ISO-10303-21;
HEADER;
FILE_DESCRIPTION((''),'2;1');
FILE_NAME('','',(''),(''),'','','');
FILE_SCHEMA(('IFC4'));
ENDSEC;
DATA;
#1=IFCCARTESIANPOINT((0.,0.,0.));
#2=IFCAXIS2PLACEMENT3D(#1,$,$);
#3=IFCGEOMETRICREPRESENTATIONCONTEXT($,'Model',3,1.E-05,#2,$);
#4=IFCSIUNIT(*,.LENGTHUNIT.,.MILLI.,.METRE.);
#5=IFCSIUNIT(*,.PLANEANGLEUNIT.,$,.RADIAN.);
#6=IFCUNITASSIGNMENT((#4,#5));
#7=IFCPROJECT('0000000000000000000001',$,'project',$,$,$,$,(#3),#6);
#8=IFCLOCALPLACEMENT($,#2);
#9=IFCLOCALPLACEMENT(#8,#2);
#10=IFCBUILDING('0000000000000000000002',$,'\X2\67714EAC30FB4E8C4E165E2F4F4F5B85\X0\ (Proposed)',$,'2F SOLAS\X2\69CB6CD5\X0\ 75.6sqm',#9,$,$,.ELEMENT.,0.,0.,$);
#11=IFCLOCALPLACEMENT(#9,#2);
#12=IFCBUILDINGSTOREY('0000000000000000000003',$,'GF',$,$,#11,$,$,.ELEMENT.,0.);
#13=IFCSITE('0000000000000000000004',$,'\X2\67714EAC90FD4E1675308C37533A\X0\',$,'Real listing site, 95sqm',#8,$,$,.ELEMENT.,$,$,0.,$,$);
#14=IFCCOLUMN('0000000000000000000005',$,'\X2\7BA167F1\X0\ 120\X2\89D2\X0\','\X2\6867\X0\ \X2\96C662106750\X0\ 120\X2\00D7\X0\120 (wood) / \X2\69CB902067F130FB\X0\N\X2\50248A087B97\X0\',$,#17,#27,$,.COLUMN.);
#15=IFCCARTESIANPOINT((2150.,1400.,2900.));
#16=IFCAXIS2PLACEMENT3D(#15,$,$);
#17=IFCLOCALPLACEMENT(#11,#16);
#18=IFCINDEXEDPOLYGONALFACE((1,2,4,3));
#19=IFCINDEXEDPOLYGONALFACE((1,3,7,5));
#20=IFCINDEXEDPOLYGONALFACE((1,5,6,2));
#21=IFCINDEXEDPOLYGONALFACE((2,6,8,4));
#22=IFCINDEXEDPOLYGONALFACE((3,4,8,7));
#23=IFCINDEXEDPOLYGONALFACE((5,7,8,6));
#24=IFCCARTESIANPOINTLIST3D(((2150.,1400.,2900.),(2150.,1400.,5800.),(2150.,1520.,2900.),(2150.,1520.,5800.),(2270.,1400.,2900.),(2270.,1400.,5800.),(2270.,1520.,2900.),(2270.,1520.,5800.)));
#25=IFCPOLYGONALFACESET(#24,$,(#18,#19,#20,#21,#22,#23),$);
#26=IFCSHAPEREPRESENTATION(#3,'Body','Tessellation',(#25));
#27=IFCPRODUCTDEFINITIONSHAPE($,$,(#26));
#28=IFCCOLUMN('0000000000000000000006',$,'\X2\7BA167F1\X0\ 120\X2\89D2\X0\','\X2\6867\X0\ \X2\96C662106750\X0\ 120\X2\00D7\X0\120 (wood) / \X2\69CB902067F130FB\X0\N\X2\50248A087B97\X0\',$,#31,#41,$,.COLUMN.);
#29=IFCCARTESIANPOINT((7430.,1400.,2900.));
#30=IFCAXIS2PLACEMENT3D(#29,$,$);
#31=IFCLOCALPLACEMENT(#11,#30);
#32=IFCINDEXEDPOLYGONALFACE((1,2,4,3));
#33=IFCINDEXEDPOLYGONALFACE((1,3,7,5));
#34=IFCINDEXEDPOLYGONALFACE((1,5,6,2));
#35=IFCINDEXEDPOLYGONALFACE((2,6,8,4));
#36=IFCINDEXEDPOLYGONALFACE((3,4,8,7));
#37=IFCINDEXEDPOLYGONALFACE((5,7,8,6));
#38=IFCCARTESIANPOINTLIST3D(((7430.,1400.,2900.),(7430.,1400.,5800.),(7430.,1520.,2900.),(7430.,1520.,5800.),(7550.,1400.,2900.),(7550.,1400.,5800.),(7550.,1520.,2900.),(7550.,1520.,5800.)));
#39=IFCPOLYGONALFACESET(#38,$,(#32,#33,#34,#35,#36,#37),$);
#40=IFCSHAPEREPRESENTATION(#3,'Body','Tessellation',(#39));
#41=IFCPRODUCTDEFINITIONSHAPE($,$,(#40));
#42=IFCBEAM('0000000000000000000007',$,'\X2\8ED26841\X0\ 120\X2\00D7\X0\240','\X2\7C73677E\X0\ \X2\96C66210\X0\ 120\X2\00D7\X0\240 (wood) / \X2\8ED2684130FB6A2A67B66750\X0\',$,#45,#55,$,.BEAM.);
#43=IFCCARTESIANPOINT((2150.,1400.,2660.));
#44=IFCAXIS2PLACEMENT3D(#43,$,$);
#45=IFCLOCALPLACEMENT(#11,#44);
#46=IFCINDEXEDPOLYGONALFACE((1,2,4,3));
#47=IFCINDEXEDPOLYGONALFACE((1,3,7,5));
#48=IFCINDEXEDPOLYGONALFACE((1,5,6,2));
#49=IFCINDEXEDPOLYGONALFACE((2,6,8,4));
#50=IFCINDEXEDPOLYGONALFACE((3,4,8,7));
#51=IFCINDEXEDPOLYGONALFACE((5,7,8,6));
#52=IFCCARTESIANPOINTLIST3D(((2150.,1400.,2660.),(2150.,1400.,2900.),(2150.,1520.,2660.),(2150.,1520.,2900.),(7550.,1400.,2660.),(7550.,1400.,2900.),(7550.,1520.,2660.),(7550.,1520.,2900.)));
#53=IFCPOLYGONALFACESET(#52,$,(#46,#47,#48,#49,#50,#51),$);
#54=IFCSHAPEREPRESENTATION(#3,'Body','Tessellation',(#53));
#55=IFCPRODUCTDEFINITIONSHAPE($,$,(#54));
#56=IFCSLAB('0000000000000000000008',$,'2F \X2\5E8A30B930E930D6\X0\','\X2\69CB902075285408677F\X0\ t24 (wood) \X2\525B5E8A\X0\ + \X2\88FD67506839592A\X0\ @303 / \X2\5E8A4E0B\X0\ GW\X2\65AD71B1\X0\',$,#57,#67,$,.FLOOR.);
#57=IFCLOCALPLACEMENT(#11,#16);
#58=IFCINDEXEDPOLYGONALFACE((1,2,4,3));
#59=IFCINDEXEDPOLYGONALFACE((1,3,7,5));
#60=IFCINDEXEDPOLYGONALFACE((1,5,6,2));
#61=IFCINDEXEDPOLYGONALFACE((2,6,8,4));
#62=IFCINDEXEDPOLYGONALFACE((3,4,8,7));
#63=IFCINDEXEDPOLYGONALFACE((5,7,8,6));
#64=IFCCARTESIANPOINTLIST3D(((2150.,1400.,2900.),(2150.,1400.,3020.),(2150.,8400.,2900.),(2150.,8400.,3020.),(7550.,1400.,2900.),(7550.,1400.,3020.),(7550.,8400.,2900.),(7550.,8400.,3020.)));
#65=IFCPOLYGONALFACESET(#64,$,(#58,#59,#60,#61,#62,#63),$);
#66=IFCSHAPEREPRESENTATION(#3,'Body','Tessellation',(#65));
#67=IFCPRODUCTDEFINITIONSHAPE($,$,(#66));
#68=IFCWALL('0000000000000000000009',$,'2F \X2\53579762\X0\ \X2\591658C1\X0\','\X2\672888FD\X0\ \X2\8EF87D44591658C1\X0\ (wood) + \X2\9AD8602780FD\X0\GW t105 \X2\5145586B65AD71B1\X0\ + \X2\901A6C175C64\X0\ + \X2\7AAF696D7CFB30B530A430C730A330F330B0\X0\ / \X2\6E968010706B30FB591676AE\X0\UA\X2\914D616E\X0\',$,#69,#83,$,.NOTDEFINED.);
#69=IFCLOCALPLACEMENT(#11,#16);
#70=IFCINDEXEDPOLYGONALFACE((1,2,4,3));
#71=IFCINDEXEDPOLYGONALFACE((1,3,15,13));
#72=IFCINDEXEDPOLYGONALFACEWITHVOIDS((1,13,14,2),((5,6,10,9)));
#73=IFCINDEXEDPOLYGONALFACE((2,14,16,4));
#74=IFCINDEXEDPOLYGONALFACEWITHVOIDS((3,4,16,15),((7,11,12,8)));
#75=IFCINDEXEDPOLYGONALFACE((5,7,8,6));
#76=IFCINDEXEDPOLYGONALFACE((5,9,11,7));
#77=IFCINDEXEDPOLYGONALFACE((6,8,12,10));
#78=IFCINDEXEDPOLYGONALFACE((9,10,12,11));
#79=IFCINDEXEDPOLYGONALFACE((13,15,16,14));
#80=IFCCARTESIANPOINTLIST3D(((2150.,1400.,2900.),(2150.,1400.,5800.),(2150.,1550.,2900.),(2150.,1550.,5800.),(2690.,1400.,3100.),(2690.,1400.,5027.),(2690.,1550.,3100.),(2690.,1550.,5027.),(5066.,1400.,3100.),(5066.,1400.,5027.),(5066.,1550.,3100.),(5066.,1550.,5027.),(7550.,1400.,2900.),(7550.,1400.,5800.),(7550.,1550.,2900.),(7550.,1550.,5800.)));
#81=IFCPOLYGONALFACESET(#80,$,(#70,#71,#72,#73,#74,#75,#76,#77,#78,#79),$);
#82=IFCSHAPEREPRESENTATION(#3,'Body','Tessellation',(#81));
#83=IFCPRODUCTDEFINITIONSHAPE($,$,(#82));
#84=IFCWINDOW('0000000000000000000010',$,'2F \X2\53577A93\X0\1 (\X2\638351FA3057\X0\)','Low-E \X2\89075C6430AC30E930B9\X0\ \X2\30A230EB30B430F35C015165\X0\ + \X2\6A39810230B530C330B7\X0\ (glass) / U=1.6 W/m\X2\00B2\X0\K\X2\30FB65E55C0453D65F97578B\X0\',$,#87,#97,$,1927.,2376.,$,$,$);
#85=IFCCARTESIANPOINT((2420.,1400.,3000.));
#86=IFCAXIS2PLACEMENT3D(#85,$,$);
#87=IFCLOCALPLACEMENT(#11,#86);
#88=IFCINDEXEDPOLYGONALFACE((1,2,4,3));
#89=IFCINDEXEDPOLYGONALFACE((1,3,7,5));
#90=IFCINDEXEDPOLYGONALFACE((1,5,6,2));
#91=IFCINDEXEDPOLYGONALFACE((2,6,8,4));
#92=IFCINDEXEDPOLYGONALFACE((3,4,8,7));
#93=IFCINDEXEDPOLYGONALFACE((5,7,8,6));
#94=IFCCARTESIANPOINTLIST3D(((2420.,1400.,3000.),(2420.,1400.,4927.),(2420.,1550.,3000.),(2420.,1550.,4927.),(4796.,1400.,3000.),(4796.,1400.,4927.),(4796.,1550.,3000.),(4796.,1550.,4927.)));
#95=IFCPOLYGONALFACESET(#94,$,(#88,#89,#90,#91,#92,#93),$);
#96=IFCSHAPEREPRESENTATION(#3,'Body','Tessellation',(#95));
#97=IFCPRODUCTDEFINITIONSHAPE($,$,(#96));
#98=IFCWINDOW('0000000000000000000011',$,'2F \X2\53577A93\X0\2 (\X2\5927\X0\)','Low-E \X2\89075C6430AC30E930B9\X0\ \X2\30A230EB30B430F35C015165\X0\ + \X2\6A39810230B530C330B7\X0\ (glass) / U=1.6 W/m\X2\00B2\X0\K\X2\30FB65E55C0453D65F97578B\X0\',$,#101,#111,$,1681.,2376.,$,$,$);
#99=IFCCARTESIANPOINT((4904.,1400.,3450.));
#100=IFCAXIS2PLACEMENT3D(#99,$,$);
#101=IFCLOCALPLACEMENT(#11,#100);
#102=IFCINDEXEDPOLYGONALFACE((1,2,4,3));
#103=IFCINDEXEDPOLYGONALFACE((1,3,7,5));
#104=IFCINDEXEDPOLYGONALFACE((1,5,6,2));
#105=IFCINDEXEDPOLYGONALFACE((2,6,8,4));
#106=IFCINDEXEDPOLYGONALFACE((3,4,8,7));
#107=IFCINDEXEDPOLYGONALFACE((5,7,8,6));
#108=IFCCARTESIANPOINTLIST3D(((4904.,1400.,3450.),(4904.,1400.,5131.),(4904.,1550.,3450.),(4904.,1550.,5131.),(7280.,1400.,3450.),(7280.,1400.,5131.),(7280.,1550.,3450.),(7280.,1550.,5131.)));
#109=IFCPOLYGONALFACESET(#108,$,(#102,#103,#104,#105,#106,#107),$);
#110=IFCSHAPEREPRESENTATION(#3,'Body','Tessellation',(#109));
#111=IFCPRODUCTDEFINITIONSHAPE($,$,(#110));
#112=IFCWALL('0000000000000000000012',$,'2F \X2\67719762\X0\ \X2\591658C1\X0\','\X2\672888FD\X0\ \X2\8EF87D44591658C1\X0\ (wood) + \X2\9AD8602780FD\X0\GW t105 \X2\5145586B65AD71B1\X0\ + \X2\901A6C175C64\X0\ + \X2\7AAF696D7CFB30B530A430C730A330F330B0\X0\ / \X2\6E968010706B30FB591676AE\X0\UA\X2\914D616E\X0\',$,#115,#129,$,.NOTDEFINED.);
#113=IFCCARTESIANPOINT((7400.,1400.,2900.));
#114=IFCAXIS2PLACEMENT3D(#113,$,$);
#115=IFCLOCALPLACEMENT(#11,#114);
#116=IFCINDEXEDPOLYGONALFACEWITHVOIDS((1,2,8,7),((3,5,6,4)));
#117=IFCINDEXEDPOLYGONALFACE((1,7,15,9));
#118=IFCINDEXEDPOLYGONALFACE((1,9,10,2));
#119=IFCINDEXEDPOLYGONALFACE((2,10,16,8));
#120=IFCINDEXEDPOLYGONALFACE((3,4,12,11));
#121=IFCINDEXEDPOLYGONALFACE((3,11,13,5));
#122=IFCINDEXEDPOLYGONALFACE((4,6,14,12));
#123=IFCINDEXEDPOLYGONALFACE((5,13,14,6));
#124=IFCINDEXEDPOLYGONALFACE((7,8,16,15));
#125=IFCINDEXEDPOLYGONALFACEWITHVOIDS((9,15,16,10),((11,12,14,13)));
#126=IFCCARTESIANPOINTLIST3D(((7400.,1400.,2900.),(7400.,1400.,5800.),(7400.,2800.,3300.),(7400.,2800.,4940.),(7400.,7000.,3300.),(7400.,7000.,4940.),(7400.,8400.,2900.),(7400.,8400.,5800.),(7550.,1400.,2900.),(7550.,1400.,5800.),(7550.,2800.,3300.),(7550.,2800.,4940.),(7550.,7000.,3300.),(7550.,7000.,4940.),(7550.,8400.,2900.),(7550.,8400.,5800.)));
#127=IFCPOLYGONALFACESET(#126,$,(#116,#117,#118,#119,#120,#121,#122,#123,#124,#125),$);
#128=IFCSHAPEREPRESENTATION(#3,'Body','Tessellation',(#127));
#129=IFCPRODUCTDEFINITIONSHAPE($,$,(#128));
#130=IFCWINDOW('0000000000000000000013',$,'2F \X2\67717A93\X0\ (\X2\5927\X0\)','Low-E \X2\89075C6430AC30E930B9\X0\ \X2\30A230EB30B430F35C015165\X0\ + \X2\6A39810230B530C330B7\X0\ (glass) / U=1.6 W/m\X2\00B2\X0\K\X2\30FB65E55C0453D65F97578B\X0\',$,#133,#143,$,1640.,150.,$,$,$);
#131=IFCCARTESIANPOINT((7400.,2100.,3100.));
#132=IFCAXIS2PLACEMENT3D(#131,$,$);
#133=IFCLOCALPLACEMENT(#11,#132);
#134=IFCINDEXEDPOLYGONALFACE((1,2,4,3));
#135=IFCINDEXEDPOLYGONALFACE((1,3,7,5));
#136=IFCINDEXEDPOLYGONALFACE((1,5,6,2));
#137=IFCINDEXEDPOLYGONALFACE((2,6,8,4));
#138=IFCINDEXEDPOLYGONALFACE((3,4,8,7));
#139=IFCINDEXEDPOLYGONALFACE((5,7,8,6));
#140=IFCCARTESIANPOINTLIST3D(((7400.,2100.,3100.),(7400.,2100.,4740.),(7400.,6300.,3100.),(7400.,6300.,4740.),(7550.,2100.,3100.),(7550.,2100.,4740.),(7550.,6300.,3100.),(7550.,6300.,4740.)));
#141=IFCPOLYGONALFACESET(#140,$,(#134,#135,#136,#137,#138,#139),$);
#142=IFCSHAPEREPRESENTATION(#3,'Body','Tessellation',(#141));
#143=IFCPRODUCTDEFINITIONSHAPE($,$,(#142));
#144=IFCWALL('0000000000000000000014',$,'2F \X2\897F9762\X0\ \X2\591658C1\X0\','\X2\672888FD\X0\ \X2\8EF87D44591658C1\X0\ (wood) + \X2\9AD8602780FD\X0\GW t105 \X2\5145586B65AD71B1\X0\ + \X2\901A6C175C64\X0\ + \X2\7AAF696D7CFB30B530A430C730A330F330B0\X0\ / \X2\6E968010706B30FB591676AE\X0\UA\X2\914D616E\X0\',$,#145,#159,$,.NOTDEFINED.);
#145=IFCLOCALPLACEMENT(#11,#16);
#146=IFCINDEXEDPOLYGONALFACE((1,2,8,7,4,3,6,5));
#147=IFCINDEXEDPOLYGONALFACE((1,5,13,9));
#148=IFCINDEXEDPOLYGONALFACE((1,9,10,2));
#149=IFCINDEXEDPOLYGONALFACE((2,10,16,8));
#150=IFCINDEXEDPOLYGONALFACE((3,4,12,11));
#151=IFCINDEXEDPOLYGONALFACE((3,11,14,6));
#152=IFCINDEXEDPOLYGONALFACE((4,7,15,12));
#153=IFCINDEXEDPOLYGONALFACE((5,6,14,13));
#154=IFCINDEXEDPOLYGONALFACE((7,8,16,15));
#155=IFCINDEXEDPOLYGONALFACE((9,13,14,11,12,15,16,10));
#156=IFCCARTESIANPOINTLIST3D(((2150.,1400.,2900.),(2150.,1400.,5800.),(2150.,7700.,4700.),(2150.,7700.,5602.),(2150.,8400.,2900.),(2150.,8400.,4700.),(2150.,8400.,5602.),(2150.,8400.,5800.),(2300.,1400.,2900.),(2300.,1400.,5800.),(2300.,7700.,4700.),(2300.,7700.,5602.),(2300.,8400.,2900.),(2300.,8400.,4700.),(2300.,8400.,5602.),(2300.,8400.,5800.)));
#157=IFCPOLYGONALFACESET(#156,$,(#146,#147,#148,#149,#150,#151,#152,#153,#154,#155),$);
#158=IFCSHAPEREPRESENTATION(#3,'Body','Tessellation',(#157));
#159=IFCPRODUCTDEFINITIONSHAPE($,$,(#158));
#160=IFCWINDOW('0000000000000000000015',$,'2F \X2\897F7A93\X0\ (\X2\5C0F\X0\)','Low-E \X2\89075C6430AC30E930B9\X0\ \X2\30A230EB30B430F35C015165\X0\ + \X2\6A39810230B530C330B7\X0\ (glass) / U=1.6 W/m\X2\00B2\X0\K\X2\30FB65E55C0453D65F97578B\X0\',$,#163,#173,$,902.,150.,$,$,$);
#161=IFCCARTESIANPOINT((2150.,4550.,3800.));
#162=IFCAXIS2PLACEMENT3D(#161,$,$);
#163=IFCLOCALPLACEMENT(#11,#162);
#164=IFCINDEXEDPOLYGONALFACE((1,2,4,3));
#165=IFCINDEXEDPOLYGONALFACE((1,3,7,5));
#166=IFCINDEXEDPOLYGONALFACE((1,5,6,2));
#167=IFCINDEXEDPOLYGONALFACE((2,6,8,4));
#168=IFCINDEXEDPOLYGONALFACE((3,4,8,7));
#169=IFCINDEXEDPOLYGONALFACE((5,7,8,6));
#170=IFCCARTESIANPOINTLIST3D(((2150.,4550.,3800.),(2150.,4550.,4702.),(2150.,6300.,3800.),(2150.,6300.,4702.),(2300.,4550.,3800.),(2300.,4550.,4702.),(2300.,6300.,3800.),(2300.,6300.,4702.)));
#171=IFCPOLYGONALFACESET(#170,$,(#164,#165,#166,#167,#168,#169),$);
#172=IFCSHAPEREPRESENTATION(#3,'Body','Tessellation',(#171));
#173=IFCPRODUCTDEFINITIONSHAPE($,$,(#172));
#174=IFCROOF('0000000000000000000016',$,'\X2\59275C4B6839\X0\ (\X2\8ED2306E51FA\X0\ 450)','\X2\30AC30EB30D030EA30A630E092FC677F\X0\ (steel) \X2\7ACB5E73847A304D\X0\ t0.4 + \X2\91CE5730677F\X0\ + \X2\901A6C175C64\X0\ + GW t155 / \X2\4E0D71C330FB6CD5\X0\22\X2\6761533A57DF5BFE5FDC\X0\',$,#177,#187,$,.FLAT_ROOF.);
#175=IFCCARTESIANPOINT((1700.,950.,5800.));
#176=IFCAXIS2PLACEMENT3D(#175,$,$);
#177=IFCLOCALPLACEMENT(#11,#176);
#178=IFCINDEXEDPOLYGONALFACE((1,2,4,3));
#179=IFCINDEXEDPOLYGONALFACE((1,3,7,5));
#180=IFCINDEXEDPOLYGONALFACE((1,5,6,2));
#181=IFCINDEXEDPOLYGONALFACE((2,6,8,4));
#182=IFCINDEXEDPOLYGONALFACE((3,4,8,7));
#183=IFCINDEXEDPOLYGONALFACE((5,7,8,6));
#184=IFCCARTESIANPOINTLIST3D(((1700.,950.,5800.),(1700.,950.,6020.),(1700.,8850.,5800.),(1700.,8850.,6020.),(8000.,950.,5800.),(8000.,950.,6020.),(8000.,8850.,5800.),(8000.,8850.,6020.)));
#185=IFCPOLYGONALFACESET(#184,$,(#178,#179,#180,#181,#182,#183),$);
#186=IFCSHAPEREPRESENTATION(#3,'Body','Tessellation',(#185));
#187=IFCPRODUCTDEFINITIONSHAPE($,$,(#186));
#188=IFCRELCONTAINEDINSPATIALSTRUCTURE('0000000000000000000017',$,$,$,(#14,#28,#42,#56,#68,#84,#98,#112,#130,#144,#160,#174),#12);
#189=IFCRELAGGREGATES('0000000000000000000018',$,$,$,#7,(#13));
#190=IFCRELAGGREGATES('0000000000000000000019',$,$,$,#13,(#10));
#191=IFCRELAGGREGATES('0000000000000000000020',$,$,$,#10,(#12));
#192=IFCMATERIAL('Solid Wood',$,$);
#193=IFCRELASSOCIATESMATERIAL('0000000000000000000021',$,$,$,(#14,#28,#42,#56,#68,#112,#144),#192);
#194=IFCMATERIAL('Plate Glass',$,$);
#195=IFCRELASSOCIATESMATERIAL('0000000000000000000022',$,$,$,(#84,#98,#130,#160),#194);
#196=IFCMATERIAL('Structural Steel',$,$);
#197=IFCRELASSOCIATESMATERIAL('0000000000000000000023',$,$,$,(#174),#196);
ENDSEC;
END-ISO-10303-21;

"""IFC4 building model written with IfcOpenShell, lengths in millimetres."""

from ifc_helpers import new_model, si_unit, frame, frame_2d, origin, place, context, project, spatial, rectangle, extrude, material, element, fill, save


model = new_model("IFC4")

# Units and contexts
model_context = context("Model", 3, precision=1e-05, world=origin())
ifc_project = project(units=[si_unit("LENGTHUNIT", "METRE", prefix="MILLI"), si_unit("PLANEANGLEUNIT", "RADIAN")], contexts=[model_context])

# Site, building, storey
site_placement = place(None, origin())
site = spatial("IfcSite", under=ifc_project, at=site_placement, Name="東京都世田谷区", ObjectType="Real listing site, 95sqm", CompositionType="ELEMENT", RefElevation=0.0)
building_placement = place(site_placement, origin())
building = spatial("IfcBuilding", under=site, at=building_placement, Name="東京・二世帯住宅 (Proposed)", ObjectType="2F SOLAS構法 75.6sqm", CompositionType="ELEMENT", ElevationOfRefHeight=0.0, ElevationOfTerrain=0.0)
storey_placement = place(building_placement, origin())
storey = spatial("IfcBuildingStorey", under=building, at=storey_placement, Name="GF", CompositionType="ELEMENT", Elevation=0.0)

# Columns
ifc_material_1 = material(Name="Solid Wood")
column_1_placement = place(storey_placement, frame((2150.0, 1400.0, 2900.0)))
element("IfcColumn", 1, at=column_1_placement, inside=storey, material=ifc_material_1, Name="管柱 120角", Description="桧 集成材 120×120 (wood) / 構造柱・N値計算", PredefinedType="COLUMN", context=model_context, shape_type="SweptSolid", body=[
    extrude(rectangle(XDim=120.0, YDim=120.0, at=frame_2d((60.0, 60.0))), frame((2150.0, 1400.0, 2900.0)), (0.0, 0.0, 1.0), 2900.0),
])
column_2_placement = place(storey_placement, frame((7430.0, 1400.0, 2900.0)))
element("IfcColumn", 2, at=column_2_placement, inside=storey, material=ifc_material_1, Name="管柱 120角", Description="桧 集成材 120×120 (wood) / 構造柱・N値計算", PredefinedType="COLUMN", context=model_context, shape_type="SweptSolid", body=[
    extrude(rectangle(XDim=120.0, YDim=120.0, at=frame_2d((60.0, 60.0))), frame((7430.0, 1400.0, 2900.0)), (0.0, 0.0, 1.0), 2900.0),
])

# Beam
beam_1_placement = place(storey_placement, frame((2150.0, 1400.0, 2660.0)))
element("IfcBeam", 3, at=beam_1_placement, inside=storey, material=ifc_material_1, Name="軒桁 120×240", Description="米松 集成 120×240 (wood) / 軒桁・横架材", PredefinedType="BEAM", context=model_context, shape_type="SweptSolid", body=[
    extrude(rectangle(XDim=5400.0, YDim=120.0, at=frame_2d((2700.0, 60.0))), frame((2150.0, 1400.0, 2660.0)), (0.0, 0.0, 1.0), 240.0),
])

# Slab
slab_placement = place(storey_placement, frame((2150.0, 1400.0, 2900.0)))
element("IfcSlab", 4, at=slab_placement, inside=storey, material=ifc_material_1, Name="2F 床スラブ", Description="構造用合板 t24 (wood) 剛床 + 製材根太 @303 / 床下 GW断熱", PredefinedType="FLOOR", context=model_context, shape_type="SweptSolid", body=[
    extrude(rectangle(XDim=5400.0, YDim=7000.0, at=frame_2d((2700.0, 3500.0))), frame((2150.0, 1400.0, 2900.0)), (0.0, 0.0, 1.0), 120.0),
])

# Wall, openings, windows
wall_1_placement = place(storey_placement, frame((2150.0, 1400.0, 2900.0)))
wall_1 = element("IfcWall", 5, at=wall_1_placement, inside=storey, material=ifc_material_1, Name="2F 南面 外壁", Description="木製 軸組外壁 (wood) + 高性能GW t105 充填断熱 + 通気層 + 窯業系サイディング / 準耐火・外皮UA配慮", PredefinedType="NOTDEFINED", context=model_context, shape_type="SweptSolid", body=[
    extrude(rectangle(XDim=5400.0, YDim=150.0, at=frame_2d((2700.0, 75.0))), frame((2150.0, 1400.0, 2900.0)), (0.0, 0.0, 1.0), 2900.0),
])
opening_1_placement = place(storey_placement, frame((2420.0, 1400.0, 3000.0)))
opening_1 = element("IfcOpeningElement", 6, at=opening_1_placement, cuts=wall_1, PredefinedType="NOTDEFINED", context=model_context, shape_type="SweptSolid", body=[
    extrude(rectangle(XDim=2376.0, YDim=150.0, at=frame_2d((1188.0, 75.0))), frame((2420.0, 1400.0, 3000.0)), (0.0, 0.0, 1.0), 1927.0),
])
opening_2_placement = place(storey_placement, frame((4904.0, 1400.0, 3450.0)))
opening_2 = element("IfcOpeningElement", 7, at=opening_2_placement, cuts=wall_1, PredefinedType="NOTDEFINED", context=model_context, shape_type="SweptSolid", body=[
    extrude(rectangle(XDim=2376.0, YDim=150.0, at=frame_2d((1188.0, 75.0))), frame((4904.0, 1400.0, 3450.0)), (0.0, 0.0, 1.0), 1681.0),
])
ifc_material_2 = material(Name="Plate Glass")
window_1_placement = place(storey_placement, frame((2420.0, 1400.0, 3000.0)))
window_1 = element("IfcWindow", 8, at=window_1_placement, inside=storey, material=ifc_material_2, Name="2F 南窓1 (掃出し)", Description="Low-E 複層ガラス アルゴン封入 + 樹脂サッシ (glass) / U=1.6 W/m²K・日射取得型", OverallHeight=1927.0, OverallWidth=2376.0, context=model_context, shape_type="SweptSolid", body=[
    extrude(rectangle(XDim=2376.0, YDim=150.0, at=frame_2d((1188.0, 75.0))), frame((2420.0, 1400.0, 3000.0)), (0.0, 0.0, 1.0), 1927.0),
])
fill(opening_1, window_1)
window_2_placement = place(storey_placement, frame((4904.0, 1400.0, 3450.0)))
window_2 = element("IfcWindow", 9, at=window_2_placement, inside=storey, material=ifc_material_2, Name="2F 南窓2 (大)", Description="Low-E 複層ガラス アルゴン封入 + 樹脂サッシ (glass) / U=1.6 W/m²K・日射取得型", OverallHeight=1681.0, OverallWidth=2376.0, context=model_context, shape_type="SweptSolid", body=[
    extrude(rectangle(XDim=2376.0, YDim=150.0, at=frame_2d((1188.0, 75.0))), frame((4904.0, 1400.0, 3450.0)), (0.0, 0.0, 1.0), 1681.0),
])
fill(opening_2, window_2)

# Walls, openings, windows
wall_2_placement = place(storey_placement, frame((7400.0, 1400.0, 2900.0)))
wall_2 = element("IfcWall", 10, at=wall_2_placement, inside=storey, material=ifc_material_1, Name="2F 東面 外壁", Description="木製 軸組外壁 (wood) + 高性能GW t105 充填断熱 + 通気層 + 窯業系サイディング / 準耐火・外皮UA配慮", PredefinedType="NOTDEFINED", context=model_context, shape_type="SweptSolid", body=[
    extrude(rectangle(XDim=150.0, YDim=7000.0, at=frame_2d((75.0, 3500.0))), frame((7400.0, 1400.0, 2900.0)), (0.0, 0.0, 1.0), 2900.0),
])
opening_3_placement = place(storey_placement, frame((7400.0, 2100.0, 3100.0)))
opening_3 = element("IfcOpeningElement", 11, at=opening_3_placement, cuts=wall_2, PredefinedType="NOTDEFINED", context=model_context, shape_type="SweptSolid", body=[
    extrude(rectangle(XDim=150.0, YDim=4200.0, at=frame_2d((75.0, 2100.0))), frame((7400.0, 2100.0, 3100.0)), (0.0, 0.0, 1.0), 1640.0),
])
window_3_placement = place(storey_placement, frame((7400.0, 2100.0, 3100.0)))
window_3 = element("IfcWindow", 12, at=window_3_placement, inside=storey, material=ifc_material_2, Name="2F 東窓 (大)", Description="Low-E 複層ガラス アルゴン封入 + 樹脂サッシ (glass) / U=1.6 W/m²K・日射取得型", OverallHeight=1640.0, OverallWidth=150.0, context=model_context, shape_type="SweptSolid", body=[
    extrude(rectangle(XDim=150.0, YDim=4200.0, at=frame_2d((75.0, 2100.0))), frame((7400.0, 2100.0, 3100.0)), (0.0, 0.0, 1.0), 1640.0),
])
fill(opening_3, window_3)
wall_3_placement = place(storey_placement, frame((2150.0, 1400.0, 2900.0)))
wall_3 = element("IfcWall", 13, at=wall_3_placement, inside=storey, material=ifc_material_1, Name="2F 西面 外壁", Description="木製 軸組外壁 (wood) + 高性能GW t105 充填断熱 + 通気層 + 窯業系サイディング / 準耐火・外皮UA配慮", PredefinedType="NOTDEFINED", context=model_context, shape_type="SweptSolid", body=[
    extrude(rectangle(XDim=150.0, YDim=7000.0, at=frame_2d((75.0, 3500.0))), frame((2150.0, 1400.0, 2900.0)), (0.0, 0.0, 1.0), 2900.0),
])
opening_4_placement = place(storey_placement, frame((2150.0, 4550.0, 3800.0)))
opening_4 = element("IfcOpeningElement", 14, at=opening_4_placement, cuts=wall_3, PredefinedType="NOTDEFINED", context=model_context, shape_type="SweptSolid", body=[
    extrude(rectangle(XDim=150.0, YDim=1750.0, at=frame_2d((75.0, 875.0))), frame((2150.0, 4550.0, 3800.0)), (0.0, 0.0, 1.0), 902.0),
])
window_4_placement = place(storey_placement, frame((2150.0, 4550.0, 3800.0)))
window_4 = element("IfcWindow", 15, at=window_4_placement, inside=storey, material=ifc_material_2, Name="2F 西窓 (小)", Description="Low-E 複層ガラス アルゴン封入 + 樹脂サッシ (glass) / U=1.6 W/m²K・日射取得型", OverallHeight=902.0, OverallWidth=150.0, context=model_context, shape_type="SweptSolid", body=[
    extrude(rectangle(XDim=150.0, YDim=1750.0, at=frame_2d((75.0, 875.0))), frame((2150.0, 4550.0, 3800.0)), (0.0, 0.0, 1.0), 902.0),
])
fill(opening_4, window_4)

# Roof
ifc_material_3 = material(Name="Structural Steel")
roof_placement = place(storey_placement, frame((1700.0, 950.0, 5800.0)))
element("IfcRoof", 16, at=roof_placement, inside=storey, material=ifc_material_3, Name="大屋根 (軒の出 450)", Description="ガルバリウム鋼板 (steel) 立平葺き t0.4 + 野地板 + 通気層 + GW t155 / 不燃・法22条区域対応", PredefinedType="FLAT_ROOF", context=model_context, shape_type="SweptSolid", body=[
    extrude(rectangle(XDim=6300.0, YDim=7900.0, at=frame_2d((3150.0, 3950.0))), frame((1700.0, 950.0, 5800.0)), (0.0, 0.0, 1.0), 220.0),
])

save(model, "model.ifc")
